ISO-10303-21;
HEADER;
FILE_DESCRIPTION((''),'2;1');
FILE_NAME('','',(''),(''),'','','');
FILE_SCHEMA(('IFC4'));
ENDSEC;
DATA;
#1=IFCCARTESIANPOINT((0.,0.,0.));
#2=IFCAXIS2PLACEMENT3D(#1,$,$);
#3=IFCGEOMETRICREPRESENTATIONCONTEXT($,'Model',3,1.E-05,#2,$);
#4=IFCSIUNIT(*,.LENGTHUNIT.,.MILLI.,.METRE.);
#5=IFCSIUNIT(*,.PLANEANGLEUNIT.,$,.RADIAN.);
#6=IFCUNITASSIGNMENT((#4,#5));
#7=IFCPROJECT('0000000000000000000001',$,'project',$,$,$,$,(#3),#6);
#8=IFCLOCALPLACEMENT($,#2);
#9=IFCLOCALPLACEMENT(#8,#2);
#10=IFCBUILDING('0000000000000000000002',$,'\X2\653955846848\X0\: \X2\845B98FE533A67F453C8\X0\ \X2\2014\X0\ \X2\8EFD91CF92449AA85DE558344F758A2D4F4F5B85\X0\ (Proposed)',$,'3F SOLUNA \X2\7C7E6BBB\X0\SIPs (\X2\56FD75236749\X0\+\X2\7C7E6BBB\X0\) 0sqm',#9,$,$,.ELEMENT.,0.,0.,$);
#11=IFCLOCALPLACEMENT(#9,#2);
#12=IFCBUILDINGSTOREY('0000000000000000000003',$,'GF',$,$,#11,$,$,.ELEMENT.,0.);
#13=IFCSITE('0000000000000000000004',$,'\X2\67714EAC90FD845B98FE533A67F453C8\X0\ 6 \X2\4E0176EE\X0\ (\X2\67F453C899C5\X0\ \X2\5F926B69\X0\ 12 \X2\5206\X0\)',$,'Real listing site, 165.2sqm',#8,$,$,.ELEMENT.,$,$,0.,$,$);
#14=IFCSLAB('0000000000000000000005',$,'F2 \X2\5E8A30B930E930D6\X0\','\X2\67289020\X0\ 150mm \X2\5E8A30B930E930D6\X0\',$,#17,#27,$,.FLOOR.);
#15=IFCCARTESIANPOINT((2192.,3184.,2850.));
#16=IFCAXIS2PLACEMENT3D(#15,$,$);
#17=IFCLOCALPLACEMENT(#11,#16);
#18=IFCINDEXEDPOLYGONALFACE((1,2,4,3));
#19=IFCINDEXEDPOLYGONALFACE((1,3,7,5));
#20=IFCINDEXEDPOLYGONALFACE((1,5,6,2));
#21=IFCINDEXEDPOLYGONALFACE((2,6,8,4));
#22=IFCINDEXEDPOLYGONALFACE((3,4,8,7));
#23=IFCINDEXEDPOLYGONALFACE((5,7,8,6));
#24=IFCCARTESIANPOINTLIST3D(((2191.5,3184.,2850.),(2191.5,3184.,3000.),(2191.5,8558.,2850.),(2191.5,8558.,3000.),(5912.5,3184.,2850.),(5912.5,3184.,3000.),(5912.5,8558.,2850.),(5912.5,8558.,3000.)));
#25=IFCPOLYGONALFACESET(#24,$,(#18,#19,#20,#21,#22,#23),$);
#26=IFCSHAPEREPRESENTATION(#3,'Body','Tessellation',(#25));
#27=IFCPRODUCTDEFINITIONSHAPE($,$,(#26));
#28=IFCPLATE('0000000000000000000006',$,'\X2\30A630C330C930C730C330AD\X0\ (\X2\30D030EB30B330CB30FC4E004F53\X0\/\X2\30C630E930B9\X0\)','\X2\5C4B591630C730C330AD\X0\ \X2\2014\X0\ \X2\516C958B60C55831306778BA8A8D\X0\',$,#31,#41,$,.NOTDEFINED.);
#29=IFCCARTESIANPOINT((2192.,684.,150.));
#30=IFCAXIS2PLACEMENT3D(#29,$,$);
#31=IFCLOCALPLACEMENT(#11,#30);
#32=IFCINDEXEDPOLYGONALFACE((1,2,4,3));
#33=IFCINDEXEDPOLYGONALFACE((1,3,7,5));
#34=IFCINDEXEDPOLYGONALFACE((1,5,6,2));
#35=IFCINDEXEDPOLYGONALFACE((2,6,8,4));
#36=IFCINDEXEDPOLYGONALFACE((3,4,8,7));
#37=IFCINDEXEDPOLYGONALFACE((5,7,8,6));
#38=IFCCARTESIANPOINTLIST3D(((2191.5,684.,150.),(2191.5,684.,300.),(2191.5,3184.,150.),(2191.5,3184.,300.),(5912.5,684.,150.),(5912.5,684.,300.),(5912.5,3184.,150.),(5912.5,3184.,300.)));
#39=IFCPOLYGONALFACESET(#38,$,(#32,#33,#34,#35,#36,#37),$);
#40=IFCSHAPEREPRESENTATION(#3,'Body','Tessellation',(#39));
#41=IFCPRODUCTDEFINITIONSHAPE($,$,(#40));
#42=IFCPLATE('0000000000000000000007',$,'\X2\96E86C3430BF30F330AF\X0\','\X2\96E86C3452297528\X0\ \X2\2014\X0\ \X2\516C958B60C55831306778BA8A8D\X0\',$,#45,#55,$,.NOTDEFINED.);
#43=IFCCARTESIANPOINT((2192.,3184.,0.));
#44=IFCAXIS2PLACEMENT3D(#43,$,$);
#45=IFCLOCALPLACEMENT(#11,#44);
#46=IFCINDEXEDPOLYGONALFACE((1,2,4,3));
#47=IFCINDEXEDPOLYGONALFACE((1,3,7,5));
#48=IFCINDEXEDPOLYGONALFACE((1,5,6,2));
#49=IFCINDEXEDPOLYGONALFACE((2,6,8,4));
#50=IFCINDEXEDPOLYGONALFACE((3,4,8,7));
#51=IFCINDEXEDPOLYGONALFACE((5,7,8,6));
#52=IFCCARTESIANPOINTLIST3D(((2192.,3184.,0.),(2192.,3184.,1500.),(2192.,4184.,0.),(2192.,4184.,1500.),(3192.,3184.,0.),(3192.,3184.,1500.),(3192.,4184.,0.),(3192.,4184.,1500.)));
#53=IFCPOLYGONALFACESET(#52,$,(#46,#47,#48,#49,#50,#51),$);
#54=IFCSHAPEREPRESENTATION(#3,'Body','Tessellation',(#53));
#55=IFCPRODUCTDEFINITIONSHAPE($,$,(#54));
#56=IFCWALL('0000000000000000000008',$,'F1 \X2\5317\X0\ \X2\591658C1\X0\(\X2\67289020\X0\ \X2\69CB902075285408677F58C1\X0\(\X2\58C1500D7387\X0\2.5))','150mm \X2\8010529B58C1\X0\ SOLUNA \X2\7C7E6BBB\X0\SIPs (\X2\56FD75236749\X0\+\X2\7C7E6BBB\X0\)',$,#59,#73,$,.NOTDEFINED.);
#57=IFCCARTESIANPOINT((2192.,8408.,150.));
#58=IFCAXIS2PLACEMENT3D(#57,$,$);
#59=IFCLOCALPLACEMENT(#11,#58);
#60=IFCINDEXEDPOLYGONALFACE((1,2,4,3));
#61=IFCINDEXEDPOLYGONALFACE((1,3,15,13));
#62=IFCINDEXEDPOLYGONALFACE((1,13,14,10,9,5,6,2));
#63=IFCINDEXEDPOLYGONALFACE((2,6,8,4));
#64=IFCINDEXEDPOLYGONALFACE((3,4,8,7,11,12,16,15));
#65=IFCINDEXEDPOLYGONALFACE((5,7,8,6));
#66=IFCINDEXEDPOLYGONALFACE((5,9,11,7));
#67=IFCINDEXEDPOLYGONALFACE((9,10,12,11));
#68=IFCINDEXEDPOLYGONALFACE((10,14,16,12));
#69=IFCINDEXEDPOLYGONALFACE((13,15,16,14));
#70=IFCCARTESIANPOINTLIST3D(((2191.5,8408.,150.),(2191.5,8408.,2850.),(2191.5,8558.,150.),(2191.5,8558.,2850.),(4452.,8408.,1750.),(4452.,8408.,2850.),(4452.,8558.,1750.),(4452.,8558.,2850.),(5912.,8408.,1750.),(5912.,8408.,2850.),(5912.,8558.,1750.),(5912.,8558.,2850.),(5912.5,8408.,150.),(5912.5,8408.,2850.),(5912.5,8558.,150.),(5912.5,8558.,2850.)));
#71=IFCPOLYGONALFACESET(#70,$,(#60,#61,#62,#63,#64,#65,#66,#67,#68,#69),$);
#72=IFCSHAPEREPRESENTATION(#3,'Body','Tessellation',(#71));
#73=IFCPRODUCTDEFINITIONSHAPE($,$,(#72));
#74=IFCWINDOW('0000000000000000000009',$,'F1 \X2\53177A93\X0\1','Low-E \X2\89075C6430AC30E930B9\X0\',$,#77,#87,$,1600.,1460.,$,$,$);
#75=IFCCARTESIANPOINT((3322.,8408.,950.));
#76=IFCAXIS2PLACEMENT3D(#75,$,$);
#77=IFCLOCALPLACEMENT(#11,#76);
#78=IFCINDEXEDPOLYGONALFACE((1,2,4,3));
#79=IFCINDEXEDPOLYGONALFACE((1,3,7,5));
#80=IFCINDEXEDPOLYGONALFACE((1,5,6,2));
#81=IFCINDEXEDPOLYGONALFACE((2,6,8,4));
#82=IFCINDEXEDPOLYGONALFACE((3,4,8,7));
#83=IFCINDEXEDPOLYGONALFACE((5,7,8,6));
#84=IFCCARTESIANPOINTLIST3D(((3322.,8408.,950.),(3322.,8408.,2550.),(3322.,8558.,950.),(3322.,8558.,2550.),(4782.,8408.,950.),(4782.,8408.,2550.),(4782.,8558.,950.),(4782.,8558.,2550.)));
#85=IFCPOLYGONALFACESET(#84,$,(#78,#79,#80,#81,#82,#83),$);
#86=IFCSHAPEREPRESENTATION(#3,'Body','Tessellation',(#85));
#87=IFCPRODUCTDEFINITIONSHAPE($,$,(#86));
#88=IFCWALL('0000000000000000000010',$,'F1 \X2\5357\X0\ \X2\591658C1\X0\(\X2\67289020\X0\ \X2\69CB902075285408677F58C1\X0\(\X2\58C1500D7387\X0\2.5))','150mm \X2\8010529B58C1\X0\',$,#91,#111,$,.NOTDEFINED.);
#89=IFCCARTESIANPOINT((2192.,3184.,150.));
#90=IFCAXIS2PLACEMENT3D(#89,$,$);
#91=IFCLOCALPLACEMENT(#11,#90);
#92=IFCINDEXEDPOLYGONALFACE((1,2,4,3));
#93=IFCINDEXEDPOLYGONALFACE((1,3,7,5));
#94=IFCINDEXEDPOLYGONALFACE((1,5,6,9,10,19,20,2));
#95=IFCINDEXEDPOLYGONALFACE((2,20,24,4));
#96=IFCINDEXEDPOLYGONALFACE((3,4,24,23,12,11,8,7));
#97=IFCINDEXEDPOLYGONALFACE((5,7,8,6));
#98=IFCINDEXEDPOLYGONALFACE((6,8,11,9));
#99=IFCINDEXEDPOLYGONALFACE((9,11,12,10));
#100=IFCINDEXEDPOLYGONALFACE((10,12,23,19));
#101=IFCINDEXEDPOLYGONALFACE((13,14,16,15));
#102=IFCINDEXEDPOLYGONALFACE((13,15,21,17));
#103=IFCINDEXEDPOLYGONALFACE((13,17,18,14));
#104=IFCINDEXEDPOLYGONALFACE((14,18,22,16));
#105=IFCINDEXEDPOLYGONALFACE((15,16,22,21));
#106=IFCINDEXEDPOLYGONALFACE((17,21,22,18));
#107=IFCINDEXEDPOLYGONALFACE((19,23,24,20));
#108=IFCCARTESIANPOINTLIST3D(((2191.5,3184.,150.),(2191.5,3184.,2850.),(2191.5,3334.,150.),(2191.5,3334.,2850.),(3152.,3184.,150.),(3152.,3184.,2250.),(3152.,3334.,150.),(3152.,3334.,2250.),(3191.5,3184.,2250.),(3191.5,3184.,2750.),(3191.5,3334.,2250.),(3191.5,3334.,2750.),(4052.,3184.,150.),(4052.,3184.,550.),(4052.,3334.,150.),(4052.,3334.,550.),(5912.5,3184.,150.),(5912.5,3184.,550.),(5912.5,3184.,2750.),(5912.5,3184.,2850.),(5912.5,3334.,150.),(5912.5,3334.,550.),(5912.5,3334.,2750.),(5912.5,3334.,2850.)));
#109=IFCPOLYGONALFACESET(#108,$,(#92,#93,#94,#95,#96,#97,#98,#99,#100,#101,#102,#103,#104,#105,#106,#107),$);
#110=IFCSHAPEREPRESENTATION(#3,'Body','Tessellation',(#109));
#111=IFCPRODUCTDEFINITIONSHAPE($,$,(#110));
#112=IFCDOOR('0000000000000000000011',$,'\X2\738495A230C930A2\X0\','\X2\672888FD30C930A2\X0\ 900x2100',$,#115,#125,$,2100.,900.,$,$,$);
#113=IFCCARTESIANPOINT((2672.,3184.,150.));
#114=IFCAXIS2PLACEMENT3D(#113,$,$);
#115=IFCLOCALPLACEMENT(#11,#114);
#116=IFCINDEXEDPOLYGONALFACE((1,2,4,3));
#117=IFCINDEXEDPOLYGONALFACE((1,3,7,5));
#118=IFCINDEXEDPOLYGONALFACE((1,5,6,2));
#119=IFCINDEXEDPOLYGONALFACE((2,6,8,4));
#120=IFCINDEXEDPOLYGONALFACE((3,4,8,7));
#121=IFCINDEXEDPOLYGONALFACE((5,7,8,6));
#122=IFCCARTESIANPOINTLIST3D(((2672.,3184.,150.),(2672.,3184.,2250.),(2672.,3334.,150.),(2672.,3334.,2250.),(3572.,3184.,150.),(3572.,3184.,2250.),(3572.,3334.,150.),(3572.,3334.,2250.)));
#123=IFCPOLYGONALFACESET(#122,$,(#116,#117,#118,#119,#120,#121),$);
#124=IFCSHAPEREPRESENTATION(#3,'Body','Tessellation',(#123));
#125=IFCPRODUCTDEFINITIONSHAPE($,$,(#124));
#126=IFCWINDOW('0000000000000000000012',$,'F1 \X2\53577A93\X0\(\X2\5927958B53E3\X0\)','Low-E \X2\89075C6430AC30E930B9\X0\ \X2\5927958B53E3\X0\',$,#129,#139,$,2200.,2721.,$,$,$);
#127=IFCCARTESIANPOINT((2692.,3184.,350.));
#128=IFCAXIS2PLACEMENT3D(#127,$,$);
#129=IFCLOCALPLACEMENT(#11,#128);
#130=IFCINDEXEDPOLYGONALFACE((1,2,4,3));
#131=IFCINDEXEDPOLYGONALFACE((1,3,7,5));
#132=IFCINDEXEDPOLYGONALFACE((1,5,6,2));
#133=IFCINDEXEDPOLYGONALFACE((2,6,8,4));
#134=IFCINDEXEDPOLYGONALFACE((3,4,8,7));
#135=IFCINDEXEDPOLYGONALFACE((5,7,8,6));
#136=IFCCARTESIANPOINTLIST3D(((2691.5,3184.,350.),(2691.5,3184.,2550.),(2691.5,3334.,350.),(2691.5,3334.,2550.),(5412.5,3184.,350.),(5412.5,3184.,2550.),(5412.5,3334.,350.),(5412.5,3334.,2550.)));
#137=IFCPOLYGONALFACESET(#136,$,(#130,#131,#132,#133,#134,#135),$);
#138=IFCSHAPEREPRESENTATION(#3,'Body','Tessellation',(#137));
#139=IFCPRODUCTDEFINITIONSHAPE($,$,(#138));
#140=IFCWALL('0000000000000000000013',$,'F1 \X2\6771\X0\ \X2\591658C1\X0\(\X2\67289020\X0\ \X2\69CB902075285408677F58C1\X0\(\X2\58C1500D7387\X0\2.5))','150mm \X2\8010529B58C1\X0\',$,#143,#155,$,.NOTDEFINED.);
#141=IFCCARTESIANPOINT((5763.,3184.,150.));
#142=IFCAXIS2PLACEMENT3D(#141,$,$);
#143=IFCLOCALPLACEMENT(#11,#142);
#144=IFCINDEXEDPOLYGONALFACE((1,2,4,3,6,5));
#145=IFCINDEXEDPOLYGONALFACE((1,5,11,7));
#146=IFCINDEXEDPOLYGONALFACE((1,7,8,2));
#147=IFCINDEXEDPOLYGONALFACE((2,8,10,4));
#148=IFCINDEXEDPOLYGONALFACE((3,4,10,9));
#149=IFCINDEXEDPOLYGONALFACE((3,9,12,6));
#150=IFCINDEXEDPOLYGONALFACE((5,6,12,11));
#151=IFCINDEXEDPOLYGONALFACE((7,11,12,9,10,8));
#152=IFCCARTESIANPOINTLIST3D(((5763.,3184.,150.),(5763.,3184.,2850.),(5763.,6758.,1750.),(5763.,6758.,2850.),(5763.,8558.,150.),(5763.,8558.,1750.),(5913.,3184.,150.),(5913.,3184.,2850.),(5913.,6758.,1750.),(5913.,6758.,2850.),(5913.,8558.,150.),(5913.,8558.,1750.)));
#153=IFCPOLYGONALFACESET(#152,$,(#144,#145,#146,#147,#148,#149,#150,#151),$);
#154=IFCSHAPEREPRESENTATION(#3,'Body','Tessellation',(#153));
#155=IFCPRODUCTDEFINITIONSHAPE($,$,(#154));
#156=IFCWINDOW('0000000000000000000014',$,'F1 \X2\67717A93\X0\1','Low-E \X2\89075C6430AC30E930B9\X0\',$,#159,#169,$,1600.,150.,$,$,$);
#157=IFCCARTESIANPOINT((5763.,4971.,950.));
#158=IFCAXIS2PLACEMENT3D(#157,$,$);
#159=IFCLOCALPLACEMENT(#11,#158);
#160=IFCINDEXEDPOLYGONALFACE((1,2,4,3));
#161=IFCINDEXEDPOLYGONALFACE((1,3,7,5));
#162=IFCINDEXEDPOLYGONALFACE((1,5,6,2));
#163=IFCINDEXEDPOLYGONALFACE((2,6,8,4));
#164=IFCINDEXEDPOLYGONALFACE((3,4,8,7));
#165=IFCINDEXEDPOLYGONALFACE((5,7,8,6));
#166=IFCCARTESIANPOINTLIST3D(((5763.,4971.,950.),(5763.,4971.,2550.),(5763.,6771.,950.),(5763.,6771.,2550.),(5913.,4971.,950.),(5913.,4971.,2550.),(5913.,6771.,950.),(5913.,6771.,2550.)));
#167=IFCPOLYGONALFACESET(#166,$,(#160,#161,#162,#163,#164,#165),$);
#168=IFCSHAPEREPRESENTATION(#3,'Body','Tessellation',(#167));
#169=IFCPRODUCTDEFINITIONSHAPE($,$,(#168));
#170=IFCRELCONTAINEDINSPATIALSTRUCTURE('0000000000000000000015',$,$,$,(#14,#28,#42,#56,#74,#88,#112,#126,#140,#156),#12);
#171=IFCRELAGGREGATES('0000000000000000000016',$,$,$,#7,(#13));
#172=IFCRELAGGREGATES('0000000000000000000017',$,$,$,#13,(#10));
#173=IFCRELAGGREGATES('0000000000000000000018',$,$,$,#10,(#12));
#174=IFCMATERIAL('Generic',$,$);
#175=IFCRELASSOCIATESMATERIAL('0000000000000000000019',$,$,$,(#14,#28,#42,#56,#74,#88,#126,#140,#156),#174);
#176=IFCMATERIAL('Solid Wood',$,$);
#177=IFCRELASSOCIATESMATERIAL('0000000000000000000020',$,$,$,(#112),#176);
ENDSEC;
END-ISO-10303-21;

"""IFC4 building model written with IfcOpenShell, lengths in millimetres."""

from ifc_helpers import new_model, si_unit, frame, frame_2d, origin, place, context, project, spatial, rectangle, extrude, material, element, fill, save


model = new_model("IFC4")

# Units and contexts
model_context = context("Model", 3, precision=1e-05, world=origin())
ifc_project = project(units=[si_unit("LENGTHUNIT", "METRE", prefix="MILLI"), si_unit("PLANEANGLEUNIT", "RADIAN")], contexts=[model_context])

# Site, building, storey
site_placement = place(None, origin())
site = spatial("IfcSite", under=ifc_project, at=site_placement, Name="東京都葛飾区柴又 6 丁目 (柴又駅 徒歩 12 分)", ObjectType="Real listing site, 165.2sqm", CompositionType="ELEMENT", RefElevation=0.0)
building_placement = place(site_placement, origin())
building = spatial("IfcBuilding", under=site, at=building_placement, Name="改善案: 葛飾区柴又 — 軽量鉄骨工場併設住宅 (Proposed)", ObjectType="3F SOLUNA 籾殻SIPs (国産杉+籾殻) 0sqm", CompositionType="ELEMENT", ElevationOfRefHeight=0.0, ElevationOfTerrain=0.0)
storey_placement = place(building_placement, origin())
storey = spatial("IfcBuildingStorey", under=building, at=storey_placement, Name="GF", CompositionType="ELEMENT", Elevation=0.0)

# Slab
ifc_material_1 = material(Name="Generic")
slab_1_placement = place(storey_placement, frame((2192.0, 3184.0, 2850.0)))
element("IfcSlab", 1, at=slab_1_placement, inside=storey, material=ifc_material_1, Name="F2 床スラブ", Description="木造 150mm 床スラブ", PredefinedType="FLOOR", context=model_context, shape_type="SweptSolid", body=[
    extrude(rectangle(XDim=3721.0, YDim=5374.0, at=frame_2d((1860.0, 2687.0))), frame((2192.0, 3184.0, 2850.0)), (0.0, 0.0, 1.0), 150.0),
])

# Plates
plate_1_placement = place(storey_placement, frame((2192.0, 684.0, 150.0)))
element("IfcPlate", 2, at=plate_1_placement, inside=storey, material=ifc_material_1, Name="ウッドデッキ (バルコニー一体/テラス)", Description="屋外デッキ — 公開情報で確認", PredefinedType="NOTDEFINED", context=model_context, shape_type="SweptSolid", body=[
    extrude(rectangle(XDim=3721.0, YDim=2500.0, at=frame_2d((1860.0, 1250.0))), frame((2192.0, 684.0, 150.0)), (0.0, 0.0, 1.0), 150.0),
])
plate_2_placement = place(storey_placement, frame((2192.0, 3184.0, 0.0)))
element("IfcPlate", 3, at=plate_2_placement, inside=storey, material=ifc_material_1, Name="雨水タンク", Description="雨水利用 — 公開情報で確認", PredefinedType="NOTDEFINED", context=model_context, shape_type="SweptSolid", body=[
    extrude(rectangle(XDim=1000.0, YDim=1000.0, at=frame_2d((500.0, 500.0))), frame((2192.0, 3184.0, 0.0)), (0.0, 0.0, 1.0), 1500.0),
])

# Wall, opening, window
wall_1_placement = place(storey_placement, frame((2192.0, 8408.0, 150.0)))
wall_1 = element("IfcWall", 4, at=wall_1_placement, inside=storey, material=ifc_material_1, Name="F1 北 外壁(木造 構造用合板壁(壁倍率2.5))", Description="150mm 耐力壁 SOLUNA 籾殻SIPs (国産杉+籾殻)", PredefinedType="NOTDEFINED", context=model_context, shape_type="SweptSolid", body=[
    extrude(rectangle(XDim=3721.0, YDim=150.0, at=frame_2d((1860.0, 75.0))), frame((2192.0, 8408.0, 150.0)), (0.0, 0.0, 1.0), 2700.0),
])
opening_1_placement = place(storey_placement, frame((3322.0, 8408.0, 950.0)))
opening_1 = element("IfcOpeningElement", 5, at=opening_1_placement, cuts=wall_1, PredefinedType="NOTDEFINED", context=model_context, shape_type="SweptSolid", body=[
    extrude(rectangle(XDim=1460.0, YDim=150.0, at=frame_2d((730.0, 75.0))), frame((3322.0, 8408.0, 950.0)), (0.0, 0.0, 1.0), 1600.0),
])
window_1_placement = place(storey_placement, frame((3322.0, 8408.0, 950.0)))
window_1 = element("IfcWindow", 6, at=window_1_placement, inside=storey, material=ifc_material_1, Name="F1 北窓1", Description="Low-E 複層ガラス", OverallHeight=1600.0, OverallWidth=1460.0, context=model_context, shape_type="SweptSolid", body=[
    extrude(rectangle(XDim=1460.0, YDim=150.0, at=frame_2d((730.0, 75.0))), frame((3322.0, 8408.0, 950.0)), (0.0, 0.0, 1.0), 1600.0),
])
fill(opening_1, window_1)

# Wall, openings, door, window
wall_2_placement = place(storey_placement, frame((2192.0, 3184.0, 150.0)))
wall_2 = element("IfcWall", 7, at=wall_2_placement, inside=storey, material=ifc_material_1, Name="F1 南 外壁(木造 構造用合板壁(壁倍率2.5))", Description="150mm 耐力壁", PredefinedType="NOTDEFINED", context=model_context, shape_type="SweptSolid", body=[
    extrude(rectangle(XDim=3721.0, YDim=150.0, at=frame_2d((1860.0, 75.0))), frame((2192.0, 3184.0, 150.0)), (0.0, 0.0, 1.0), 2700.0),
])
opening_2_placement = place(storey_placement, frame((2672.0, 3184.0, 150.0)))
opening_2 = element("IfcOpeningElement", 8, at=opening_2_placement, cuts=wall_2, PredefinedType="NOTDEFINED", context=model_context, shape_type="SweptSolid", body=[
    extrude(rectangle(XDim=900.0, YDim=150.0, at=frame_2d((450.0, 75.0))), frame((2672.0, 3184.0, 150.0)), (0.0, 0.0, 1.0), 2100.0),
])
opening_3_placement = place(storey_placement, frame((2692.0, 3184.0, 350.0)))
opening_3 = element("IfcOpeningElement", 9, at=opening_3_placement, cuts=wall_2, PredefinedType="NOTDEFINED", context=model_context, shape_type="SweptSolid", body=[
    extrude(rectangle(XDim=2721.0, YDim=150.0, at=frame_2d((1360.0, 75.0))), frame((2692.0, 3184.0, 350.0)), (0.0, 0.0, 1.0), 2200.0),
])
ifc_material_2 = material(Name="Solid Wood")
door_placement = place(storey_placement, frame((2672.0, 3184.0, 150.0)))
door = element("IfcDoor", 10, at=door_placement, inside=storey, material=ifc_material_2, Name="玄関ドア", Description="木製ドア 900x2100", OverallHeight=2100.0, OverallWidth=900.0, context=model_context, shape_type="SweptSolid", body=[
    extrude(rectangle(XDim=900.0, YDim=150.0, at=frame_2d((450.0, 75.0))), frame((2672.0, 3184.0, 150.0)), (0.0, 0.0, 1.0), 2100.0),
])
fill(opening_2, door)
window_2_placement = place(storey_placement, frame((2692.0, 3184.0, 350.0)))
window_2 = element("IfcWindow", 11, at=window_2_placement, inside=storey, material=ifc_material_1, Name="F1 南窓(大開口)", Description="Low-E 複層ガラス 大開口", OverallHeight=2200.0, OverallWidth=2721.0, context=model_context, shape_type="SweptSolid", body=[
    extrude(rectangle(XDim=2721.0, YDim=150.0, at=frame_2d((1360.0, 75.0))), frame((2692.0, 3184.0, 350.0)), (0.0, 0.0, 1.0), 2200.0),
])
fill(opening_3, window_2)

# Wall, opening, window
wall_3_placement = place(storey_placement, frame((5763.0, 3184.0, 150.0)))
wall_3 = element("IfcWall", 12, at=wall_3_placement, inside=storey, material=ifc_material_1, Name="F1 東 外壁(木造 構造用合板壁(壁倍率2.5))", Description="150mm 耐力壁", PredefinedType="NOTDEFINED", context=model_context, shape_type="SweptSolid", body=[
    extrude(rectangle(XDim=150.0, YDim=5374.0, at=frame_2d((75.0, 2687.0))), frame((5763.0, 3184.0, 150.0)), (0.0, 0.0, 1.0), 2700.0),
])
opening_4_placement = place(storey_placement, frame((5763.0, 4971.0, 950.0)))
opening_4 = element("IfcOpeningElement", 13, at=opening_4_placement, cuts=wall_3, PredefinedType="NOTDEFINED", context=model_context, shape_type="SweptSolid", body=[
    extrude(rectangle(XDim=150.0, YDim=1800.0, at=frame_2d((75.0, 900.0))), frame((5763.0, 4971.0, 950.0)), (0.0, 0.0, 1.0), 1600.0),
])
window_3_placement = place(storey_placement, frame((5763.0, 4971.0, 950.0)))
window_3 = element("IfcWindow", 14, at=window_3_placement, inside=storey, material=ifc_material_1, Name="F1 東窓1", Description="Low-E 複層ガラス", OverallHeight=1600.0, OverallWidth=150.0, context=model_context, shape_type="SweptSolid", body=[
    extrude(rectangle(XDim=150.0, YDim=1800.0, at=frame_2d((75.0, 900.0))), frame((5763.0, 4971.0, 950.0)), (0.0, 0.0, 1.0), 1600.0),
])
fill(opening_4, window_3)

save(model, "model.ifc")
